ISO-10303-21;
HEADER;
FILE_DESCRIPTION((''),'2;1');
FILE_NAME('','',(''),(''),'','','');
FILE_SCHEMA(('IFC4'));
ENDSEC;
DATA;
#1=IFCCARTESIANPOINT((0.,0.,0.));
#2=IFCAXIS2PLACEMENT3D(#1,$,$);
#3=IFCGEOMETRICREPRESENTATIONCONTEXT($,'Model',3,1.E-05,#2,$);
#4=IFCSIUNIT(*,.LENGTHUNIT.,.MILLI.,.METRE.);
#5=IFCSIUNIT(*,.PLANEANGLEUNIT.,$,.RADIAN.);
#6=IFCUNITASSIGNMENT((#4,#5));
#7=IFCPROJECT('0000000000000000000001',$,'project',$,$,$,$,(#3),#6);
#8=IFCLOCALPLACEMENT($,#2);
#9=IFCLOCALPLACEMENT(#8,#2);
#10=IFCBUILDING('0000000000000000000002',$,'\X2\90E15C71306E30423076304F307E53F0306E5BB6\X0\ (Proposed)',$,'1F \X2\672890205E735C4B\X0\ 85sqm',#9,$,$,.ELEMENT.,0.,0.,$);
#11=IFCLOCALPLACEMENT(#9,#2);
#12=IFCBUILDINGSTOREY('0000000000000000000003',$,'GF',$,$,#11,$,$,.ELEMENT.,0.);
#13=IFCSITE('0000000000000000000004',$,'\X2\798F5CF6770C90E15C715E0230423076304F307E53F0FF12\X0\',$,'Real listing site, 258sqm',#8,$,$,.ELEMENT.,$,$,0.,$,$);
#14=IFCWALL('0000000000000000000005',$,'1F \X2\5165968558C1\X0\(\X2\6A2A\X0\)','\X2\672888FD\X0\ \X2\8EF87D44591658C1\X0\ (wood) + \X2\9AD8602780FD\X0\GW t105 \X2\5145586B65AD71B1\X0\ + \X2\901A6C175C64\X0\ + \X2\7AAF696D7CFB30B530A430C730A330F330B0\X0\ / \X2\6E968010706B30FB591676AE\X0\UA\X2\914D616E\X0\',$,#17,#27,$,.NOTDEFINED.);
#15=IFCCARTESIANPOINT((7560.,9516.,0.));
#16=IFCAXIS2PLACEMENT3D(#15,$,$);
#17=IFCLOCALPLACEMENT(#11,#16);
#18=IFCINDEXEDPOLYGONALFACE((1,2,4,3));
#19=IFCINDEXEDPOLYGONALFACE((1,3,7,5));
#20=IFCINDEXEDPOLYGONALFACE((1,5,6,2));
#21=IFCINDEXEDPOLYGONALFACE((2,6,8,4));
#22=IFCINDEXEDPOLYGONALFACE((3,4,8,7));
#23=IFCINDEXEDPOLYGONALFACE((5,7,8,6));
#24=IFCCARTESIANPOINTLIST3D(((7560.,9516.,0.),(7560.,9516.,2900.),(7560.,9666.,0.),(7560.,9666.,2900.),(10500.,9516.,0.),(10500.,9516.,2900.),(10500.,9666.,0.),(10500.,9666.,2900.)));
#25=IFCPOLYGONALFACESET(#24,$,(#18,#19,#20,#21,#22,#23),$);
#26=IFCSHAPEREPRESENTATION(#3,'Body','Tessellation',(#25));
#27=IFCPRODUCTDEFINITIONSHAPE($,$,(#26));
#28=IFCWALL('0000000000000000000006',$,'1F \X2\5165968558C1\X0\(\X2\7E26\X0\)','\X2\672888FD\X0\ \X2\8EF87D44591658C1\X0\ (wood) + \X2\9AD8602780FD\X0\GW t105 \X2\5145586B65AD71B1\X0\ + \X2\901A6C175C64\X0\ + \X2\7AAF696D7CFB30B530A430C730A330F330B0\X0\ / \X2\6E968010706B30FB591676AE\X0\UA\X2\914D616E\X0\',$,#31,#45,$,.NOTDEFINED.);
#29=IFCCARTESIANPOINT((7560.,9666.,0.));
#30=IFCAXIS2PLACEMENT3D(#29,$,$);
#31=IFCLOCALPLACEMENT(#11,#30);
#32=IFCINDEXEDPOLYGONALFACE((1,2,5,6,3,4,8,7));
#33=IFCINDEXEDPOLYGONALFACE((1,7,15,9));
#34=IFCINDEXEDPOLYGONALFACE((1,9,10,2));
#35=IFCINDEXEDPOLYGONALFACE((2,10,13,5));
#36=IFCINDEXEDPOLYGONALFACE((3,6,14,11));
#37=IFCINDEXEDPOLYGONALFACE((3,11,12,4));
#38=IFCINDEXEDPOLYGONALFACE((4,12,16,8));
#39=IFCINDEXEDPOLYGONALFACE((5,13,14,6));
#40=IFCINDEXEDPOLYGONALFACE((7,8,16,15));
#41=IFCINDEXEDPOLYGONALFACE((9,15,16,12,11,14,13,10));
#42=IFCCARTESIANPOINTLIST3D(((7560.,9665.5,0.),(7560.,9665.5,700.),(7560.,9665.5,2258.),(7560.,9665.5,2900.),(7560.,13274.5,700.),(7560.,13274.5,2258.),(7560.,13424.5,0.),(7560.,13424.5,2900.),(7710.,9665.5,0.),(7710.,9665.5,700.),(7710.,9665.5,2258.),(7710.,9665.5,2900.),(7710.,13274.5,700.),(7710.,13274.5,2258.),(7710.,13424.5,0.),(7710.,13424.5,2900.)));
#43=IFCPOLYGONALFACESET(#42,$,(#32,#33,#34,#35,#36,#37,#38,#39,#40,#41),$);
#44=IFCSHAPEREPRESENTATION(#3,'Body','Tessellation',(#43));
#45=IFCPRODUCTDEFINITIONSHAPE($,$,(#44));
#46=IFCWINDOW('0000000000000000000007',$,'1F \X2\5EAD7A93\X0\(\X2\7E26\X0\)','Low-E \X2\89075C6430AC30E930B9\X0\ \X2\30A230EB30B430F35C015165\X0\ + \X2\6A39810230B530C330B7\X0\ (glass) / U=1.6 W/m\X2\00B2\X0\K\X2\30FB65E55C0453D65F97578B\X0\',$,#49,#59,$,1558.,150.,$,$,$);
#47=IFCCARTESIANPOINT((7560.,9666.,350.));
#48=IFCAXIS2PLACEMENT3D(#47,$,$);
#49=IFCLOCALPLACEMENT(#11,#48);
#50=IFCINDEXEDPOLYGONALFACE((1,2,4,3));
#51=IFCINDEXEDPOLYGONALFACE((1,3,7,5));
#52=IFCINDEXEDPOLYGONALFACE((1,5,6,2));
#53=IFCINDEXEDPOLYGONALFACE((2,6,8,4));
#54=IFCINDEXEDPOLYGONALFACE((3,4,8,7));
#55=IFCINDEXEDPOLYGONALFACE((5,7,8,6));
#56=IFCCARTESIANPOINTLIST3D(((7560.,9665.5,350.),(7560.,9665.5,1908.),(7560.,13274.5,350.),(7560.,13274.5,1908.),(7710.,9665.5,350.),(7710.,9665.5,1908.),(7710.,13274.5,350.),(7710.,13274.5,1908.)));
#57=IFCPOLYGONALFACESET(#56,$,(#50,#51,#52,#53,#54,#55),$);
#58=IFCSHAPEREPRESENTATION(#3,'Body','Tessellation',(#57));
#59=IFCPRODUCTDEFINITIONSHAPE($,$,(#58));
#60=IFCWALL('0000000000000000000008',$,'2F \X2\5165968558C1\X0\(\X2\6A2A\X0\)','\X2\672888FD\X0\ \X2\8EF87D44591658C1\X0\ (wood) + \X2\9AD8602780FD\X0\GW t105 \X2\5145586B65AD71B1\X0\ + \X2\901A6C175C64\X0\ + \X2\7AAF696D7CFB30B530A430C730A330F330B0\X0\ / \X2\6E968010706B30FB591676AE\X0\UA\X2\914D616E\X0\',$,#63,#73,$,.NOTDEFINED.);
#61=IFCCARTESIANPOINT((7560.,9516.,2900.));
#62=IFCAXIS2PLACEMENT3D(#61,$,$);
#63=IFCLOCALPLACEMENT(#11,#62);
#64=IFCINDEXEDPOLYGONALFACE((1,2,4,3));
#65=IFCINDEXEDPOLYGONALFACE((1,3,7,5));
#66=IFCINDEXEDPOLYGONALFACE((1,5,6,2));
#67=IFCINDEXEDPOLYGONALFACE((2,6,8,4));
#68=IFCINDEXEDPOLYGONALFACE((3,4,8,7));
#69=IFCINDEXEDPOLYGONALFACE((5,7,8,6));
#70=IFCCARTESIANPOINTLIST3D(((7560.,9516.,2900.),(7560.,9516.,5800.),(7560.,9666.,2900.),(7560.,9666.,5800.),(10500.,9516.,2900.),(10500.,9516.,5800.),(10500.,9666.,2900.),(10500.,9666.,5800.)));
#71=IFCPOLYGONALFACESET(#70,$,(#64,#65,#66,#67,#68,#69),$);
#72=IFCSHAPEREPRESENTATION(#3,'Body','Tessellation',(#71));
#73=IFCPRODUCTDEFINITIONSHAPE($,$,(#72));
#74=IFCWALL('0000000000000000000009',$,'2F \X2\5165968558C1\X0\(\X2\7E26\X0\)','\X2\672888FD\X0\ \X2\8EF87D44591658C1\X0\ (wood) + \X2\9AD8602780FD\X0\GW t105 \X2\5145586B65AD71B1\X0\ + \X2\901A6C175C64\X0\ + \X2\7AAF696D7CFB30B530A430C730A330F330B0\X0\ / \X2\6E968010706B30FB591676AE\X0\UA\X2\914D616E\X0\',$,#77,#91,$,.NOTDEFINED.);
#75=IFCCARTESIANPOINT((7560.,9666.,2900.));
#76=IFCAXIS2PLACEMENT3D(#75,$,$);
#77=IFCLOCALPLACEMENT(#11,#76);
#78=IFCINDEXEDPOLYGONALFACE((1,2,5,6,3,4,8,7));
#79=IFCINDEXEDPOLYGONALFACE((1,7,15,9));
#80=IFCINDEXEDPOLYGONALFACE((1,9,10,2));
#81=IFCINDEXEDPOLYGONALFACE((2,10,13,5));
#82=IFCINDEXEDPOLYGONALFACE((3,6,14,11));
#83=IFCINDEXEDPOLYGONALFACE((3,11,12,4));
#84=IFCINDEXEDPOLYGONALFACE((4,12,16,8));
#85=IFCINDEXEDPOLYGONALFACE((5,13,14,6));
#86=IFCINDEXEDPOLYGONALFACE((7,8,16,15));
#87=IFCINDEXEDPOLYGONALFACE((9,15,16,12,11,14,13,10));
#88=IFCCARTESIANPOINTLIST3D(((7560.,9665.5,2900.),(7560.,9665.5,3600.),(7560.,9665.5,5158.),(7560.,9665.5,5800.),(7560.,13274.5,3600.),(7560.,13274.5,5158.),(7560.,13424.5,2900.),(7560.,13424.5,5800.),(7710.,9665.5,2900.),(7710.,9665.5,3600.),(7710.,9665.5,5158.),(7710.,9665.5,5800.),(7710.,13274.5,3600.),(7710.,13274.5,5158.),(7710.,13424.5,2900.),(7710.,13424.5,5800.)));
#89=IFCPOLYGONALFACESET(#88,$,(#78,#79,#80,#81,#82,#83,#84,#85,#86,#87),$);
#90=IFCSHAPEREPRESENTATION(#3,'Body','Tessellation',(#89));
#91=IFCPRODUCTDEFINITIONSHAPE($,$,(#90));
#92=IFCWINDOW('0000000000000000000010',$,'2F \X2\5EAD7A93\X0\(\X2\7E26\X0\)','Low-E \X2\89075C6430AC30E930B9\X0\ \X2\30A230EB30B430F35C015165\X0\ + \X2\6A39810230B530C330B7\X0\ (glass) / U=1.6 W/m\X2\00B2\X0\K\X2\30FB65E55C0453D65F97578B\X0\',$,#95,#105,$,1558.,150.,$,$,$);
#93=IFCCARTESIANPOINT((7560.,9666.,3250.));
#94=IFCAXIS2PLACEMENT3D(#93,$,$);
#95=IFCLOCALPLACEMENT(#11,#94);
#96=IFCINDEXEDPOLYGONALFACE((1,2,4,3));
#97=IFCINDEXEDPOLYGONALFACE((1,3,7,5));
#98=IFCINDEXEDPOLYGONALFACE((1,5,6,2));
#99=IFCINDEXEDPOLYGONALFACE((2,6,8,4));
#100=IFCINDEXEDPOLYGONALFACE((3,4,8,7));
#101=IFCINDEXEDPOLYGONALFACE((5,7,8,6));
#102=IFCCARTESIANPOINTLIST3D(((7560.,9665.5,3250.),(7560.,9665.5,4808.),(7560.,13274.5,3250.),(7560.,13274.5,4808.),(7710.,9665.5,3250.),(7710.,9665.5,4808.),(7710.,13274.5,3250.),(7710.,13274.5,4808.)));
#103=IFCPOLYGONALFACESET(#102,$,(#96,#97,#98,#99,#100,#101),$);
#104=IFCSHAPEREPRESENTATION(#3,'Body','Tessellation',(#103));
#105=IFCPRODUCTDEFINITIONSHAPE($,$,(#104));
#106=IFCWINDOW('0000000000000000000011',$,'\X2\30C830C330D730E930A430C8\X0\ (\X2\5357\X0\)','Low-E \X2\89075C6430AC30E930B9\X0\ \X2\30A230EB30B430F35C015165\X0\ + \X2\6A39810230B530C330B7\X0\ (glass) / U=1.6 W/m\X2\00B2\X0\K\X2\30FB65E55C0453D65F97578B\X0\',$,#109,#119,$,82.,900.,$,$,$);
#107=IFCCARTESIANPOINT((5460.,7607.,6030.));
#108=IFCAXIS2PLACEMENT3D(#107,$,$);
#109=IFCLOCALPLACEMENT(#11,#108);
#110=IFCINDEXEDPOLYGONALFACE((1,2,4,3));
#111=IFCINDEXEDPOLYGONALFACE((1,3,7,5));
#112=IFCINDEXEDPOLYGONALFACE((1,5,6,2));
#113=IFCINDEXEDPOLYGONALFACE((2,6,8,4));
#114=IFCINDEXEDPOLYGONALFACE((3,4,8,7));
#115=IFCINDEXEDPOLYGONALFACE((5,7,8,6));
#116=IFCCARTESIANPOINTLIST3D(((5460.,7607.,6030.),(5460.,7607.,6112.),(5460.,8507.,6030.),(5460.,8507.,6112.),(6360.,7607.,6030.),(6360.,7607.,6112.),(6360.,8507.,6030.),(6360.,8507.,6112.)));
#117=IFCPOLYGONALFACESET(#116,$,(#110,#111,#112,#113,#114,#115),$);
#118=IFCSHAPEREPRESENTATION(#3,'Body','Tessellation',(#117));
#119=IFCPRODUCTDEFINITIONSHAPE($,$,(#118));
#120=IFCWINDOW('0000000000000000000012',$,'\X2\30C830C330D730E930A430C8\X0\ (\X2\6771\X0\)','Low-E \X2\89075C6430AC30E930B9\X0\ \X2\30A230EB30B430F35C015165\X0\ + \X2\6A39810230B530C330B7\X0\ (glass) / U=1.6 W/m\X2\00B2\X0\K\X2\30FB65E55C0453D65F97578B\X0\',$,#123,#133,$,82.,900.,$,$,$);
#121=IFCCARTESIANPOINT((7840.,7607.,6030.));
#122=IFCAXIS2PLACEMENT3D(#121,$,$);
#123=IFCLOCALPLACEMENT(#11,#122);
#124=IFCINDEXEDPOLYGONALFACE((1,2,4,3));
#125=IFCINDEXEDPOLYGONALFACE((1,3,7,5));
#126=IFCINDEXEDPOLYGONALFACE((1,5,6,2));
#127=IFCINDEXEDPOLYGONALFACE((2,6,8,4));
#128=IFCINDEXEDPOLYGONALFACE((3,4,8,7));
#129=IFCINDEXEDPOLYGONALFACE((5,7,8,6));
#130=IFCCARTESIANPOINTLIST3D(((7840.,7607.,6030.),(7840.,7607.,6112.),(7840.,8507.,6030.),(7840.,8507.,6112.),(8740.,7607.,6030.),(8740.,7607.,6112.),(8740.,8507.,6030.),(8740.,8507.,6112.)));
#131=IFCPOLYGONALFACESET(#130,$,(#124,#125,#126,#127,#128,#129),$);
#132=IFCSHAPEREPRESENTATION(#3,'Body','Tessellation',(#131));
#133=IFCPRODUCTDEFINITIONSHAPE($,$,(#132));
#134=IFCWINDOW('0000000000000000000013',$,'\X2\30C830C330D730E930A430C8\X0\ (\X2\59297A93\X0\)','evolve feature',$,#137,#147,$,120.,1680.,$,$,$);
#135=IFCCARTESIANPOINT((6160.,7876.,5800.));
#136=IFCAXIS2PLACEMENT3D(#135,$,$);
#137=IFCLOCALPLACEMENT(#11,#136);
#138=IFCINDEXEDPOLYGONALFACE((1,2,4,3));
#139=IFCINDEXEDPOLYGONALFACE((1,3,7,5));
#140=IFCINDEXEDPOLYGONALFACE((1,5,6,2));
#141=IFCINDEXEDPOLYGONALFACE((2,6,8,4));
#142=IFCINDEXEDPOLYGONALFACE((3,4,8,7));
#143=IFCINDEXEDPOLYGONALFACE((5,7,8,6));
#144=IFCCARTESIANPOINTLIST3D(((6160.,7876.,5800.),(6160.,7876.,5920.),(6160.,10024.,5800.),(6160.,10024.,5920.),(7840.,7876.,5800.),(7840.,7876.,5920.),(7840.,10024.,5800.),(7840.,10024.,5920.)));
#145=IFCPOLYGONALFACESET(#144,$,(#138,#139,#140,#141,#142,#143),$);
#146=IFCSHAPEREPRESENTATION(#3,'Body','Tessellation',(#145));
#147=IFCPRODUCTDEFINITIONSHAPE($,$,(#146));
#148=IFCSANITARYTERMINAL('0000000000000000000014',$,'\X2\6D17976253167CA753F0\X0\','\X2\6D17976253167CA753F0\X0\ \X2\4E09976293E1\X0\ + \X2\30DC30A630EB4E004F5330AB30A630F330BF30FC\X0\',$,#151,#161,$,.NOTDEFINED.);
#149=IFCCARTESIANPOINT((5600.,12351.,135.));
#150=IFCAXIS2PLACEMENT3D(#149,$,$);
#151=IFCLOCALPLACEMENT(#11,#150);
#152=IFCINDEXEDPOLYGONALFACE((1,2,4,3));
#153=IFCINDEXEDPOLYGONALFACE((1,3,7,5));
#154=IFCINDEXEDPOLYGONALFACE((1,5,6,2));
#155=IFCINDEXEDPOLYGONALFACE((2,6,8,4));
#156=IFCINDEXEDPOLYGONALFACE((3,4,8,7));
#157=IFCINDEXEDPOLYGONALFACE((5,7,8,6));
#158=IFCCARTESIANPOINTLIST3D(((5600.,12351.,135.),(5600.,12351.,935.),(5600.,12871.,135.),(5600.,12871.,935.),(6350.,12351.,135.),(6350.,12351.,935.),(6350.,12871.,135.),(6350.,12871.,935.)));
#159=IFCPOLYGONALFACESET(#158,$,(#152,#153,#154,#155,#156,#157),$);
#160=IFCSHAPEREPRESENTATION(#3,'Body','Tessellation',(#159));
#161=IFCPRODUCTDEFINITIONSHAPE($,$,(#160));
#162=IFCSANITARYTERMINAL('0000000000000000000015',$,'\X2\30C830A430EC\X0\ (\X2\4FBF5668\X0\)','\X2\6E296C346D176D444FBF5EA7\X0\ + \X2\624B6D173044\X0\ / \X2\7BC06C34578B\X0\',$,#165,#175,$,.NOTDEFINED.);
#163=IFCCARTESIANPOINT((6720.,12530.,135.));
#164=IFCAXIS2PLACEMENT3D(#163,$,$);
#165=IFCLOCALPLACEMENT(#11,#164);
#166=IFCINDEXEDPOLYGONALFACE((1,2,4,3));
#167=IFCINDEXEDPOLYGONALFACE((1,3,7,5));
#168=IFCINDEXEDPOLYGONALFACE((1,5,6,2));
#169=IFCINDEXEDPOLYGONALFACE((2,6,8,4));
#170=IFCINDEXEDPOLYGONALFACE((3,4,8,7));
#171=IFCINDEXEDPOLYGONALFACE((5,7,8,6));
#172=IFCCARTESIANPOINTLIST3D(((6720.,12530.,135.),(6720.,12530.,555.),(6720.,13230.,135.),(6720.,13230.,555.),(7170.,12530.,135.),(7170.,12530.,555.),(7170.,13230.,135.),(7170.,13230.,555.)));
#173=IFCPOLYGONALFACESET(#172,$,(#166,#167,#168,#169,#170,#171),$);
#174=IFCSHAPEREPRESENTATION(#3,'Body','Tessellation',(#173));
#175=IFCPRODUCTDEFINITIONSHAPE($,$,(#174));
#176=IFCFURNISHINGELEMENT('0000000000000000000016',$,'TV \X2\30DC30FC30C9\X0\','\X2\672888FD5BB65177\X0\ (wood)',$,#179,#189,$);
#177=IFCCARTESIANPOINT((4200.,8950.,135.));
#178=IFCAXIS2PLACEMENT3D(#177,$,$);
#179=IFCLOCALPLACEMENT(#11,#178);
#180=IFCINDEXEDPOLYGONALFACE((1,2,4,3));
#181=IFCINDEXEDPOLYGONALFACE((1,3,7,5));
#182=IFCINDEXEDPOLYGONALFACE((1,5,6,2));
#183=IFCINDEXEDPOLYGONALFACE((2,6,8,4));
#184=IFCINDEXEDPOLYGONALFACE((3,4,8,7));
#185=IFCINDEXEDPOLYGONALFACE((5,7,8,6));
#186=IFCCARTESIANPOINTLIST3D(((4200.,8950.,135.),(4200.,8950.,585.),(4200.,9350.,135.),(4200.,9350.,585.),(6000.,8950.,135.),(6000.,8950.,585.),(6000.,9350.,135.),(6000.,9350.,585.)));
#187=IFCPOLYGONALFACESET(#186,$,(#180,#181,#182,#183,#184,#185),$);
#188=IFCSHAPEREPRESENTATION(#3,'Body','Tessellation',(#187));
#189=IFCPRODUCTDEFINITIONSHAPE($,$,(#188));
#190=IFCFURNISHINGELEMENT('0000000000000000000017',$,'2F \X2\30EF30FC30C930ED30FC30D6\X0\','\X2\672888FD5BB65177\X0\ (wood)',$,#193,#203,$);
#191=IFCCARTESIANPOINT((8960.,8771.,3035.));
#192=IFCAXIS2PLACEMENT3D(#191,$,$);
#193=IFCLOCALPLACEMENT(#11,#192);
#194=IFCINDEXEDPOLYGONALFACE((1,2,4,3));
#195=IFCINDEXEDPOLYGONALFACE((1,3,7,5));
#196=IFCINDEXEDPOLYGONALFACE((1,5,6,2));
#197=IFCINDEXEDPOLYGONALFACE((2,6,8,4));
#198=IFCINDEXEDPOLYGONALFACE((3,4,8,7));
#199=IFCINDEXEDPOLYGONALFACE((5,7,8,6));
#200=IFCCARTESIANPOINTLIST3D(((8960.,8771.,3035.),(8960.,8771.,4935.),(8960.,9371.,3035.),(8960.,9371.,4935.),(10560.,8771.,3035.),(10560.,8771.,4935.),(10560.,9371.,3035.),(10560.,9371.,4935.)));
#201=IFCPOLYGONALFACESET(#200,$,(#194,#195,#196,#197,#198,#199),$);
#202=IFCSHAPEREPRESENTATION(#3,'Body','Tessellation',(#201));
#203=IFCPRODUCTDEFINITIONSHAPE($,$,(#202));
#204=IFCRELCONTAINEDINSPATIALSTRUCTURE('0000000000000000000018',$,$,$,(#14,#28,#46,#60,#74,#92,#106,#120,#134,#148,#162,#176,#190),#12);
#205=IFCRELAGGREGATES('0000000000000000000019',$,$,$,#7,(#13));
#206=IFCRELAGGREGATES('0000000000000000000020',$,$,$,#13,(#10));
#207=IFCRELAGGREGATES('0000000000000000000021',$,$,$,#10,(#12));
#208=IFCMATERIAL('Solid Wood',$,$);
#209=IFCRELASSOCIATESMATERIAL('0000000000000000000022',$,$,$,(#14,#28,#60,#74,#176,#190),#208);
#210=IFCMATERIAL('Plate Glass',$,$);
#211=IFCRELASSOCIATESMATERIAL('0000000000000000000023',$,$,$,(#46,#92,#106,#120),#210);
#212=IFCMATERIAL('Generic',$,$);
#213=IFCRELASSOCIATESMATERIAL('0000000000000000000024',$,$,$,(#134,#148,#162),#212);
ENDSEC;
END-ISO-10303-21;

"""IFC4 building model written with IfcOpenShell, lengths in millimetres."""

from ifc_helpers import new_model, si_unit, frame, frame_2d, origin, place, context, project, spatial, rectangle, extrude, material, element, fill, save


model = new_model("IFC4")

# Units and contexts
model_context = context("Model", 3, precision=1e-05, world=origin())
ifc_project = project(units=[si_unit("LENGTHUNIT", "METRE", prefix="MILLI"), si_unit("PLANEANGLEUNIT", "RADIAN")], contexts=[model_context])

# Site, building, storey
site_placement = place(None, origin())
site = spatial("IfcSite", under=ifc_project, at=site_placement, Name="福島県郡山市あぶくま台２", ObjectType="Real listing site, 258sqm", CompositionType="ELEMENT", RefElevation=0.0)
building_placement = place(site_placement, origin())
building = spatial("IfcBuilding", under=site, at=building_placement, Name="郡山のあぶくま台の家 (Proposed)", ObjectType="1F 木造平屋 85sqm", CompositionType="ELEMENT", ElevationOfRefHeight=0.0, ElevationOfTerrain=0.0)
storey_placement = place(building_placement, origin())
storey = spatial("IfcBuildingStorey", under=building, at=storey_placement, Name="GF", CompositionType="ELEMENT", Elevation=0.0)

# Shared definitions
ifc_material_1 = material(Name="Solid Wood")

# Wall
wall_1_placement = place(storey_placement, frame((7560.0, 9516.0, 0.0)))
element("IfcWall", 1, at=wall_1_placement, inside=storey, material=ifc_material_1, Name="1F 入隅壁(横)", Description="木製 軸組外壁 (wood) + 高性能GW t105 充填断熱 + 通気層 + 窯業系サイディング / 準耐火・外皮UA配慮", PredefinedType="NOTDEFINED", context=model_context, shape_type="SweptSolid", body=[
    extrude(rectangle(XDim=2940.0, YDim=150.0, at=frame_2d((1470.0, 75.0))), frame((7560.0, 9516.0, 0.0)), (0.0, 0.0, 1.0), 2900.0),
])

# Wall, opening, window
wall_2_placement = place(storey_placement, frame((7560.0, 9666.0, 0.0)))
wall_2 = element("IfcWall", 2, at=wall_2_placement, inside=storey, material=ifc_material_1, Name="1F 入隅壁(縦)", Description="木製 軸組外壁 (wood) + 高性能GW t105 充填断熱 + 通気層 + 窯業系サイディング / 準耐火・外皮UA配慮", PredefinedType="NOTDEFINED", context=model_context, shape_type="SweptSolid", body=[
    extrude(rectangle(XDim=150.0, YDim=3759.0, at=frame_2d((75.0, 1879.0))), frame((7560.0, 9666.0, 0.0)), (0.0, 0.0, 1.0), 2900.0),
])
opening_1_placement = place(storey_placement, frame((7560.0, 9666.0, 350.0)))
opening_1 = element("IfcOpeningElement", 3, at=opening_1_placement, cuts=wall_2, PredefinedType="NOTDEFINED", context=model_context, shape_type="SweptSolid", body=[
    extrude(rectangle(XDim=150.0, YDim=3609.0, at=frame_2d((75.0, 1804.0))), frame((7560.0, 9666.0, 350.0)), (0.0, 0.0, 1.0), 1558.0),
])
ifc_material_2 = material(Name="Plate Glass")
window_1_placement = place(storey_placement, frame((7560.0, 9666.0, 350.0)))
window_1 = element("IfcWindow", 4, at=window_1_placement, inside=storey, material=ifc_material_2, Name="1F 庭窓(縦)", Description="Low-E 複層ガラス アルゴン封入 + 樹脂サッシ (glass) / U=1.6 W/m²K・日射取得型", OverallHeight=1558.0, OverallWidth=150.0, context=model_context, shape_type="SweptSolid", body=[
    extrude(rectangle(XDim=150.0, YDim=3609.0, at=frame_2d((75.0, 1804.0))), frame((7560.0, 9666.0, 350.0)), (0.0, 0.0, 1.0), 1558.0),
])
fill(opening_1, window_1)

# Wall
wall_3_placement = place(storey_placement, frame((7560.0, 9516.0, 2900.0)))
element("IfcWall", 5, at=wall_3_placement, inside=storey, material=ifc_material_1, Name="2F 入隅壁(横)", Description="木製 軸組外壁 (wood) + 高性能GW t105 充填断熱 + 通気層 + 窯業系サイディング / 準耐火・外皮UA配慮", PredefinedType="NOTDEFINED", context=model_context, shape_type="SweptSolid", body=[
    extrude(rectangle(XDim=2940.0, YDim=150.0, at=frame_2d((1470.0, 75.0))), frame((7560.0, 9516.0, 2900.0)), (0.0, 0.0, 1.0), 2900.0),
])

# Wall, opening, window
wall_4_placement = place(storey_placement, frame((7560.0, 9666.0, 2900.0)))
wall_4 = element("IfcWall", 6, at=wall_4_placement, inside=storey, material=ifc_material_1, Name="2F 入隅壁(縦)", Description="木製 軸組外壁 (wood) + 高性能GW t105 充填断熱 + 通気層 + 窯業系サイディング / 準耐火・外皮UA配慮", PredefinedType="NOTDEFINED", context=model_context, shape_type="SweptSolid", body=[
    extrude(rectangle(XDim=150.0, YDim=3759.0, at=frame_2d((75.0, 1879.0))), frame((7560.0, 9666.0, 2900.0)), (0.0, 0.0, 1.0), 2900.0),
])
opening_2_placement = place(storey_placement, frame((7560.0, 9666.0, 3250.0)))
opening_2 = element("IfcOpeningElement", 7, at=opening_2_placement, cuts=wall_4, PredefinedType="NOTDEFINED", context=model_context, shape_type="SweptSolid", body=[
    extrude(rectangle(XDim=150.0, YDim=3609.0, at=frame_2d((75.0, 1804.0))), frame((7560.0, 9666.0, 3250.0)), (0.0, 0.0, 1.0), 1558.0),
])
window_2_placement = place(storey_placement, frame((7560.0, 9666.0, 3250.0)))
window_2 = element("IfcWindow", 8, at=window_2_placement, inside=storey, material=ifc_material_2, Name="2F 庭窓(縦)", Description="Low-E 複層ガラス アルゴン封入 + 樹脂サッシ (glass) / U=1.6 W/m²K・日射取得型", OverallHeight=1558.0, OverallWidth=150.0, context=model_context, shape_type="SweptSolid", body=[
    extrude(rectangle(XDim=150.0, YDim=3609.0, at=frame_2d((75.0, 1804.0))), frame((7560.0, 9666.0, 3250.0)), (0.0, 0.0, 1.0), 1558.0),
])
fill(opening_2, window_2)

# Windows
window_3_placement = place(storey_placement, frame((5460.0, 7607.0, 6030.0)))
element("IfcWindow", 9, at=window_3_placement, inside=storey, material=ifc_material_2, Name="トップライト (南)", Description="Low-E 複層ガラス アルゴン封入 + 樹脂サッシ (glass) / U=1.6 W/m²K・日射取得型", OverallHeight=82.0, OverallWidth=900.0, context=model_context, shape_type="SweptSolid", body=[
    extrude(rectangle(XDim=900.0, YDim=900.0, at=frame_2d((450.0, 450.0))), frame((5460.0, 7607.0, 6030.0)), (0.0, 0.0, 1.0), 82.0),
])
window_4_placement = place(storey_placement, frame((7840.0, 7607.0, 6030.0)))
element("IfcWindow", 10, at=window_4_placement, inside=storey, material=ifc_material_2, Name="トップライト (東)", Description="Low-E 複層ガラス アルゴン封入 + 樹脂サッシ (glass) / U=1.6 W/m²K・日射取得型", OverallHeight=82.0, OverallWidth=900.0, context=model_context, shape_type="SweptSolid", body=[
    extrude(rectangle(XDim=900.0, YDim=900.0, at=frame_2d((450.0, 450.0))), frame((7840.0, 7607.0, 6030.0)), (0.0, 0.0, 1.0), 82.0),
])
ifc_material_3 = material(Name="Generic")
window_5_placement = place(storey_placement, frame((6160.0, 7876.0, 5800.0)))
element("IfcWindow", 11, at=window_5_placement, inside=storey, material=ifc_material_3, Name="トップライト (天窓)", Description="evolve feature", OverallHeight=120.0, OverallWidth=1680.0, context=model_context, shape_type="SweptSolid", body=[
    extrude(rectangle(XDim=1680.0, YDim=2148.0, at=frame_2d((840.0, 1074.0))), frame((6160.0, 7876.0, 5800.0)), (0.0, 0.0, 1.0), 120.0),
])

# Sanitary terminals
sanitary_terminal_1_placement = place(storey_placement, frame((5600.0, 12351.0, 135.0)))
element("IfcSanitaryTerminal", 12, at=sanitary_terminal_1_placement, inside=storey, material=ifc_material_3, Name="洗面化粧台", Description="洗面化粧台 三面鏡 + ボウル一体カウンター", PredefinedType="NOTDEFINED", context=model_context, shape_type="SweptSolid", body=[
    extrude(rectangle(XDim=750.0, YDim=520.0, at=frame_2d((375.0, 260.0))), frame((5600.0, 12351.0, 135.0)), (0.0, 0.0, 1.0), 800.0),
])
sanitary_terminal_2_placement = place(storey_placement, frame((6720.0, 12530.0, 135.0)))
element("IfcSanitaryTerminal", 13, at=sanitary_terminal_2_placement, inside=storey, material=ifc_material_3, Name="トイレ (便器)", Description="温水洗浄便座 + 手洗い / 節水型", PredefinedType="NOTDEFINED", context=model_context, shape_type="SweptSolid", body=[
    extrude(rectangle(XDim=450.0, YDim=700.0, at=frame_2d((225.0, 350.0))), frame((6720.0, 12530.0, 135.0)), (0.0, 0.0, 1.0), 420.0),
])

# Furnishing elements
furnishing_1_placement = place(storey_placement, frame((4200.0, 8950.0, 135.0)))
element("IfcFurnishingElement", 14, at=furnishing_1_placement, inside=storey, material=ifc_material_1, Name="TV ボード", Description="木製家具 (wood)", context=model_context, shape_type="SweptSolid", body=[
    extrude(rectangle(XDim=1800.0, YDim=400.0, at=frame_2d((900.0, 200.0))), frame((4200.0, 8950.0, 135.0)), (0.0, 0.0, 1.0), 450.0),
])
furnishing_2_placement = place(storey_placement, frame((8960.0, 8771.0, 3035.0)))
element("IfcFurnishingElement", 15, at=furnishing_2_placement, inside=storey, material=ifc_material_1, Name="2F ワードローブ", Description="木製家具 (wood)", context=model_context, shape_type="SweptSolid", body=[
    extrude(rectangle(XDim=1600.0, YDim=600.0, at=frame_2d((800.0, 300.0))), frame((8960.0, 8771.0, 3035.0)), (0.0, 0.0, 1.0), 1900.0),
])

save(model, "model.ifc")
